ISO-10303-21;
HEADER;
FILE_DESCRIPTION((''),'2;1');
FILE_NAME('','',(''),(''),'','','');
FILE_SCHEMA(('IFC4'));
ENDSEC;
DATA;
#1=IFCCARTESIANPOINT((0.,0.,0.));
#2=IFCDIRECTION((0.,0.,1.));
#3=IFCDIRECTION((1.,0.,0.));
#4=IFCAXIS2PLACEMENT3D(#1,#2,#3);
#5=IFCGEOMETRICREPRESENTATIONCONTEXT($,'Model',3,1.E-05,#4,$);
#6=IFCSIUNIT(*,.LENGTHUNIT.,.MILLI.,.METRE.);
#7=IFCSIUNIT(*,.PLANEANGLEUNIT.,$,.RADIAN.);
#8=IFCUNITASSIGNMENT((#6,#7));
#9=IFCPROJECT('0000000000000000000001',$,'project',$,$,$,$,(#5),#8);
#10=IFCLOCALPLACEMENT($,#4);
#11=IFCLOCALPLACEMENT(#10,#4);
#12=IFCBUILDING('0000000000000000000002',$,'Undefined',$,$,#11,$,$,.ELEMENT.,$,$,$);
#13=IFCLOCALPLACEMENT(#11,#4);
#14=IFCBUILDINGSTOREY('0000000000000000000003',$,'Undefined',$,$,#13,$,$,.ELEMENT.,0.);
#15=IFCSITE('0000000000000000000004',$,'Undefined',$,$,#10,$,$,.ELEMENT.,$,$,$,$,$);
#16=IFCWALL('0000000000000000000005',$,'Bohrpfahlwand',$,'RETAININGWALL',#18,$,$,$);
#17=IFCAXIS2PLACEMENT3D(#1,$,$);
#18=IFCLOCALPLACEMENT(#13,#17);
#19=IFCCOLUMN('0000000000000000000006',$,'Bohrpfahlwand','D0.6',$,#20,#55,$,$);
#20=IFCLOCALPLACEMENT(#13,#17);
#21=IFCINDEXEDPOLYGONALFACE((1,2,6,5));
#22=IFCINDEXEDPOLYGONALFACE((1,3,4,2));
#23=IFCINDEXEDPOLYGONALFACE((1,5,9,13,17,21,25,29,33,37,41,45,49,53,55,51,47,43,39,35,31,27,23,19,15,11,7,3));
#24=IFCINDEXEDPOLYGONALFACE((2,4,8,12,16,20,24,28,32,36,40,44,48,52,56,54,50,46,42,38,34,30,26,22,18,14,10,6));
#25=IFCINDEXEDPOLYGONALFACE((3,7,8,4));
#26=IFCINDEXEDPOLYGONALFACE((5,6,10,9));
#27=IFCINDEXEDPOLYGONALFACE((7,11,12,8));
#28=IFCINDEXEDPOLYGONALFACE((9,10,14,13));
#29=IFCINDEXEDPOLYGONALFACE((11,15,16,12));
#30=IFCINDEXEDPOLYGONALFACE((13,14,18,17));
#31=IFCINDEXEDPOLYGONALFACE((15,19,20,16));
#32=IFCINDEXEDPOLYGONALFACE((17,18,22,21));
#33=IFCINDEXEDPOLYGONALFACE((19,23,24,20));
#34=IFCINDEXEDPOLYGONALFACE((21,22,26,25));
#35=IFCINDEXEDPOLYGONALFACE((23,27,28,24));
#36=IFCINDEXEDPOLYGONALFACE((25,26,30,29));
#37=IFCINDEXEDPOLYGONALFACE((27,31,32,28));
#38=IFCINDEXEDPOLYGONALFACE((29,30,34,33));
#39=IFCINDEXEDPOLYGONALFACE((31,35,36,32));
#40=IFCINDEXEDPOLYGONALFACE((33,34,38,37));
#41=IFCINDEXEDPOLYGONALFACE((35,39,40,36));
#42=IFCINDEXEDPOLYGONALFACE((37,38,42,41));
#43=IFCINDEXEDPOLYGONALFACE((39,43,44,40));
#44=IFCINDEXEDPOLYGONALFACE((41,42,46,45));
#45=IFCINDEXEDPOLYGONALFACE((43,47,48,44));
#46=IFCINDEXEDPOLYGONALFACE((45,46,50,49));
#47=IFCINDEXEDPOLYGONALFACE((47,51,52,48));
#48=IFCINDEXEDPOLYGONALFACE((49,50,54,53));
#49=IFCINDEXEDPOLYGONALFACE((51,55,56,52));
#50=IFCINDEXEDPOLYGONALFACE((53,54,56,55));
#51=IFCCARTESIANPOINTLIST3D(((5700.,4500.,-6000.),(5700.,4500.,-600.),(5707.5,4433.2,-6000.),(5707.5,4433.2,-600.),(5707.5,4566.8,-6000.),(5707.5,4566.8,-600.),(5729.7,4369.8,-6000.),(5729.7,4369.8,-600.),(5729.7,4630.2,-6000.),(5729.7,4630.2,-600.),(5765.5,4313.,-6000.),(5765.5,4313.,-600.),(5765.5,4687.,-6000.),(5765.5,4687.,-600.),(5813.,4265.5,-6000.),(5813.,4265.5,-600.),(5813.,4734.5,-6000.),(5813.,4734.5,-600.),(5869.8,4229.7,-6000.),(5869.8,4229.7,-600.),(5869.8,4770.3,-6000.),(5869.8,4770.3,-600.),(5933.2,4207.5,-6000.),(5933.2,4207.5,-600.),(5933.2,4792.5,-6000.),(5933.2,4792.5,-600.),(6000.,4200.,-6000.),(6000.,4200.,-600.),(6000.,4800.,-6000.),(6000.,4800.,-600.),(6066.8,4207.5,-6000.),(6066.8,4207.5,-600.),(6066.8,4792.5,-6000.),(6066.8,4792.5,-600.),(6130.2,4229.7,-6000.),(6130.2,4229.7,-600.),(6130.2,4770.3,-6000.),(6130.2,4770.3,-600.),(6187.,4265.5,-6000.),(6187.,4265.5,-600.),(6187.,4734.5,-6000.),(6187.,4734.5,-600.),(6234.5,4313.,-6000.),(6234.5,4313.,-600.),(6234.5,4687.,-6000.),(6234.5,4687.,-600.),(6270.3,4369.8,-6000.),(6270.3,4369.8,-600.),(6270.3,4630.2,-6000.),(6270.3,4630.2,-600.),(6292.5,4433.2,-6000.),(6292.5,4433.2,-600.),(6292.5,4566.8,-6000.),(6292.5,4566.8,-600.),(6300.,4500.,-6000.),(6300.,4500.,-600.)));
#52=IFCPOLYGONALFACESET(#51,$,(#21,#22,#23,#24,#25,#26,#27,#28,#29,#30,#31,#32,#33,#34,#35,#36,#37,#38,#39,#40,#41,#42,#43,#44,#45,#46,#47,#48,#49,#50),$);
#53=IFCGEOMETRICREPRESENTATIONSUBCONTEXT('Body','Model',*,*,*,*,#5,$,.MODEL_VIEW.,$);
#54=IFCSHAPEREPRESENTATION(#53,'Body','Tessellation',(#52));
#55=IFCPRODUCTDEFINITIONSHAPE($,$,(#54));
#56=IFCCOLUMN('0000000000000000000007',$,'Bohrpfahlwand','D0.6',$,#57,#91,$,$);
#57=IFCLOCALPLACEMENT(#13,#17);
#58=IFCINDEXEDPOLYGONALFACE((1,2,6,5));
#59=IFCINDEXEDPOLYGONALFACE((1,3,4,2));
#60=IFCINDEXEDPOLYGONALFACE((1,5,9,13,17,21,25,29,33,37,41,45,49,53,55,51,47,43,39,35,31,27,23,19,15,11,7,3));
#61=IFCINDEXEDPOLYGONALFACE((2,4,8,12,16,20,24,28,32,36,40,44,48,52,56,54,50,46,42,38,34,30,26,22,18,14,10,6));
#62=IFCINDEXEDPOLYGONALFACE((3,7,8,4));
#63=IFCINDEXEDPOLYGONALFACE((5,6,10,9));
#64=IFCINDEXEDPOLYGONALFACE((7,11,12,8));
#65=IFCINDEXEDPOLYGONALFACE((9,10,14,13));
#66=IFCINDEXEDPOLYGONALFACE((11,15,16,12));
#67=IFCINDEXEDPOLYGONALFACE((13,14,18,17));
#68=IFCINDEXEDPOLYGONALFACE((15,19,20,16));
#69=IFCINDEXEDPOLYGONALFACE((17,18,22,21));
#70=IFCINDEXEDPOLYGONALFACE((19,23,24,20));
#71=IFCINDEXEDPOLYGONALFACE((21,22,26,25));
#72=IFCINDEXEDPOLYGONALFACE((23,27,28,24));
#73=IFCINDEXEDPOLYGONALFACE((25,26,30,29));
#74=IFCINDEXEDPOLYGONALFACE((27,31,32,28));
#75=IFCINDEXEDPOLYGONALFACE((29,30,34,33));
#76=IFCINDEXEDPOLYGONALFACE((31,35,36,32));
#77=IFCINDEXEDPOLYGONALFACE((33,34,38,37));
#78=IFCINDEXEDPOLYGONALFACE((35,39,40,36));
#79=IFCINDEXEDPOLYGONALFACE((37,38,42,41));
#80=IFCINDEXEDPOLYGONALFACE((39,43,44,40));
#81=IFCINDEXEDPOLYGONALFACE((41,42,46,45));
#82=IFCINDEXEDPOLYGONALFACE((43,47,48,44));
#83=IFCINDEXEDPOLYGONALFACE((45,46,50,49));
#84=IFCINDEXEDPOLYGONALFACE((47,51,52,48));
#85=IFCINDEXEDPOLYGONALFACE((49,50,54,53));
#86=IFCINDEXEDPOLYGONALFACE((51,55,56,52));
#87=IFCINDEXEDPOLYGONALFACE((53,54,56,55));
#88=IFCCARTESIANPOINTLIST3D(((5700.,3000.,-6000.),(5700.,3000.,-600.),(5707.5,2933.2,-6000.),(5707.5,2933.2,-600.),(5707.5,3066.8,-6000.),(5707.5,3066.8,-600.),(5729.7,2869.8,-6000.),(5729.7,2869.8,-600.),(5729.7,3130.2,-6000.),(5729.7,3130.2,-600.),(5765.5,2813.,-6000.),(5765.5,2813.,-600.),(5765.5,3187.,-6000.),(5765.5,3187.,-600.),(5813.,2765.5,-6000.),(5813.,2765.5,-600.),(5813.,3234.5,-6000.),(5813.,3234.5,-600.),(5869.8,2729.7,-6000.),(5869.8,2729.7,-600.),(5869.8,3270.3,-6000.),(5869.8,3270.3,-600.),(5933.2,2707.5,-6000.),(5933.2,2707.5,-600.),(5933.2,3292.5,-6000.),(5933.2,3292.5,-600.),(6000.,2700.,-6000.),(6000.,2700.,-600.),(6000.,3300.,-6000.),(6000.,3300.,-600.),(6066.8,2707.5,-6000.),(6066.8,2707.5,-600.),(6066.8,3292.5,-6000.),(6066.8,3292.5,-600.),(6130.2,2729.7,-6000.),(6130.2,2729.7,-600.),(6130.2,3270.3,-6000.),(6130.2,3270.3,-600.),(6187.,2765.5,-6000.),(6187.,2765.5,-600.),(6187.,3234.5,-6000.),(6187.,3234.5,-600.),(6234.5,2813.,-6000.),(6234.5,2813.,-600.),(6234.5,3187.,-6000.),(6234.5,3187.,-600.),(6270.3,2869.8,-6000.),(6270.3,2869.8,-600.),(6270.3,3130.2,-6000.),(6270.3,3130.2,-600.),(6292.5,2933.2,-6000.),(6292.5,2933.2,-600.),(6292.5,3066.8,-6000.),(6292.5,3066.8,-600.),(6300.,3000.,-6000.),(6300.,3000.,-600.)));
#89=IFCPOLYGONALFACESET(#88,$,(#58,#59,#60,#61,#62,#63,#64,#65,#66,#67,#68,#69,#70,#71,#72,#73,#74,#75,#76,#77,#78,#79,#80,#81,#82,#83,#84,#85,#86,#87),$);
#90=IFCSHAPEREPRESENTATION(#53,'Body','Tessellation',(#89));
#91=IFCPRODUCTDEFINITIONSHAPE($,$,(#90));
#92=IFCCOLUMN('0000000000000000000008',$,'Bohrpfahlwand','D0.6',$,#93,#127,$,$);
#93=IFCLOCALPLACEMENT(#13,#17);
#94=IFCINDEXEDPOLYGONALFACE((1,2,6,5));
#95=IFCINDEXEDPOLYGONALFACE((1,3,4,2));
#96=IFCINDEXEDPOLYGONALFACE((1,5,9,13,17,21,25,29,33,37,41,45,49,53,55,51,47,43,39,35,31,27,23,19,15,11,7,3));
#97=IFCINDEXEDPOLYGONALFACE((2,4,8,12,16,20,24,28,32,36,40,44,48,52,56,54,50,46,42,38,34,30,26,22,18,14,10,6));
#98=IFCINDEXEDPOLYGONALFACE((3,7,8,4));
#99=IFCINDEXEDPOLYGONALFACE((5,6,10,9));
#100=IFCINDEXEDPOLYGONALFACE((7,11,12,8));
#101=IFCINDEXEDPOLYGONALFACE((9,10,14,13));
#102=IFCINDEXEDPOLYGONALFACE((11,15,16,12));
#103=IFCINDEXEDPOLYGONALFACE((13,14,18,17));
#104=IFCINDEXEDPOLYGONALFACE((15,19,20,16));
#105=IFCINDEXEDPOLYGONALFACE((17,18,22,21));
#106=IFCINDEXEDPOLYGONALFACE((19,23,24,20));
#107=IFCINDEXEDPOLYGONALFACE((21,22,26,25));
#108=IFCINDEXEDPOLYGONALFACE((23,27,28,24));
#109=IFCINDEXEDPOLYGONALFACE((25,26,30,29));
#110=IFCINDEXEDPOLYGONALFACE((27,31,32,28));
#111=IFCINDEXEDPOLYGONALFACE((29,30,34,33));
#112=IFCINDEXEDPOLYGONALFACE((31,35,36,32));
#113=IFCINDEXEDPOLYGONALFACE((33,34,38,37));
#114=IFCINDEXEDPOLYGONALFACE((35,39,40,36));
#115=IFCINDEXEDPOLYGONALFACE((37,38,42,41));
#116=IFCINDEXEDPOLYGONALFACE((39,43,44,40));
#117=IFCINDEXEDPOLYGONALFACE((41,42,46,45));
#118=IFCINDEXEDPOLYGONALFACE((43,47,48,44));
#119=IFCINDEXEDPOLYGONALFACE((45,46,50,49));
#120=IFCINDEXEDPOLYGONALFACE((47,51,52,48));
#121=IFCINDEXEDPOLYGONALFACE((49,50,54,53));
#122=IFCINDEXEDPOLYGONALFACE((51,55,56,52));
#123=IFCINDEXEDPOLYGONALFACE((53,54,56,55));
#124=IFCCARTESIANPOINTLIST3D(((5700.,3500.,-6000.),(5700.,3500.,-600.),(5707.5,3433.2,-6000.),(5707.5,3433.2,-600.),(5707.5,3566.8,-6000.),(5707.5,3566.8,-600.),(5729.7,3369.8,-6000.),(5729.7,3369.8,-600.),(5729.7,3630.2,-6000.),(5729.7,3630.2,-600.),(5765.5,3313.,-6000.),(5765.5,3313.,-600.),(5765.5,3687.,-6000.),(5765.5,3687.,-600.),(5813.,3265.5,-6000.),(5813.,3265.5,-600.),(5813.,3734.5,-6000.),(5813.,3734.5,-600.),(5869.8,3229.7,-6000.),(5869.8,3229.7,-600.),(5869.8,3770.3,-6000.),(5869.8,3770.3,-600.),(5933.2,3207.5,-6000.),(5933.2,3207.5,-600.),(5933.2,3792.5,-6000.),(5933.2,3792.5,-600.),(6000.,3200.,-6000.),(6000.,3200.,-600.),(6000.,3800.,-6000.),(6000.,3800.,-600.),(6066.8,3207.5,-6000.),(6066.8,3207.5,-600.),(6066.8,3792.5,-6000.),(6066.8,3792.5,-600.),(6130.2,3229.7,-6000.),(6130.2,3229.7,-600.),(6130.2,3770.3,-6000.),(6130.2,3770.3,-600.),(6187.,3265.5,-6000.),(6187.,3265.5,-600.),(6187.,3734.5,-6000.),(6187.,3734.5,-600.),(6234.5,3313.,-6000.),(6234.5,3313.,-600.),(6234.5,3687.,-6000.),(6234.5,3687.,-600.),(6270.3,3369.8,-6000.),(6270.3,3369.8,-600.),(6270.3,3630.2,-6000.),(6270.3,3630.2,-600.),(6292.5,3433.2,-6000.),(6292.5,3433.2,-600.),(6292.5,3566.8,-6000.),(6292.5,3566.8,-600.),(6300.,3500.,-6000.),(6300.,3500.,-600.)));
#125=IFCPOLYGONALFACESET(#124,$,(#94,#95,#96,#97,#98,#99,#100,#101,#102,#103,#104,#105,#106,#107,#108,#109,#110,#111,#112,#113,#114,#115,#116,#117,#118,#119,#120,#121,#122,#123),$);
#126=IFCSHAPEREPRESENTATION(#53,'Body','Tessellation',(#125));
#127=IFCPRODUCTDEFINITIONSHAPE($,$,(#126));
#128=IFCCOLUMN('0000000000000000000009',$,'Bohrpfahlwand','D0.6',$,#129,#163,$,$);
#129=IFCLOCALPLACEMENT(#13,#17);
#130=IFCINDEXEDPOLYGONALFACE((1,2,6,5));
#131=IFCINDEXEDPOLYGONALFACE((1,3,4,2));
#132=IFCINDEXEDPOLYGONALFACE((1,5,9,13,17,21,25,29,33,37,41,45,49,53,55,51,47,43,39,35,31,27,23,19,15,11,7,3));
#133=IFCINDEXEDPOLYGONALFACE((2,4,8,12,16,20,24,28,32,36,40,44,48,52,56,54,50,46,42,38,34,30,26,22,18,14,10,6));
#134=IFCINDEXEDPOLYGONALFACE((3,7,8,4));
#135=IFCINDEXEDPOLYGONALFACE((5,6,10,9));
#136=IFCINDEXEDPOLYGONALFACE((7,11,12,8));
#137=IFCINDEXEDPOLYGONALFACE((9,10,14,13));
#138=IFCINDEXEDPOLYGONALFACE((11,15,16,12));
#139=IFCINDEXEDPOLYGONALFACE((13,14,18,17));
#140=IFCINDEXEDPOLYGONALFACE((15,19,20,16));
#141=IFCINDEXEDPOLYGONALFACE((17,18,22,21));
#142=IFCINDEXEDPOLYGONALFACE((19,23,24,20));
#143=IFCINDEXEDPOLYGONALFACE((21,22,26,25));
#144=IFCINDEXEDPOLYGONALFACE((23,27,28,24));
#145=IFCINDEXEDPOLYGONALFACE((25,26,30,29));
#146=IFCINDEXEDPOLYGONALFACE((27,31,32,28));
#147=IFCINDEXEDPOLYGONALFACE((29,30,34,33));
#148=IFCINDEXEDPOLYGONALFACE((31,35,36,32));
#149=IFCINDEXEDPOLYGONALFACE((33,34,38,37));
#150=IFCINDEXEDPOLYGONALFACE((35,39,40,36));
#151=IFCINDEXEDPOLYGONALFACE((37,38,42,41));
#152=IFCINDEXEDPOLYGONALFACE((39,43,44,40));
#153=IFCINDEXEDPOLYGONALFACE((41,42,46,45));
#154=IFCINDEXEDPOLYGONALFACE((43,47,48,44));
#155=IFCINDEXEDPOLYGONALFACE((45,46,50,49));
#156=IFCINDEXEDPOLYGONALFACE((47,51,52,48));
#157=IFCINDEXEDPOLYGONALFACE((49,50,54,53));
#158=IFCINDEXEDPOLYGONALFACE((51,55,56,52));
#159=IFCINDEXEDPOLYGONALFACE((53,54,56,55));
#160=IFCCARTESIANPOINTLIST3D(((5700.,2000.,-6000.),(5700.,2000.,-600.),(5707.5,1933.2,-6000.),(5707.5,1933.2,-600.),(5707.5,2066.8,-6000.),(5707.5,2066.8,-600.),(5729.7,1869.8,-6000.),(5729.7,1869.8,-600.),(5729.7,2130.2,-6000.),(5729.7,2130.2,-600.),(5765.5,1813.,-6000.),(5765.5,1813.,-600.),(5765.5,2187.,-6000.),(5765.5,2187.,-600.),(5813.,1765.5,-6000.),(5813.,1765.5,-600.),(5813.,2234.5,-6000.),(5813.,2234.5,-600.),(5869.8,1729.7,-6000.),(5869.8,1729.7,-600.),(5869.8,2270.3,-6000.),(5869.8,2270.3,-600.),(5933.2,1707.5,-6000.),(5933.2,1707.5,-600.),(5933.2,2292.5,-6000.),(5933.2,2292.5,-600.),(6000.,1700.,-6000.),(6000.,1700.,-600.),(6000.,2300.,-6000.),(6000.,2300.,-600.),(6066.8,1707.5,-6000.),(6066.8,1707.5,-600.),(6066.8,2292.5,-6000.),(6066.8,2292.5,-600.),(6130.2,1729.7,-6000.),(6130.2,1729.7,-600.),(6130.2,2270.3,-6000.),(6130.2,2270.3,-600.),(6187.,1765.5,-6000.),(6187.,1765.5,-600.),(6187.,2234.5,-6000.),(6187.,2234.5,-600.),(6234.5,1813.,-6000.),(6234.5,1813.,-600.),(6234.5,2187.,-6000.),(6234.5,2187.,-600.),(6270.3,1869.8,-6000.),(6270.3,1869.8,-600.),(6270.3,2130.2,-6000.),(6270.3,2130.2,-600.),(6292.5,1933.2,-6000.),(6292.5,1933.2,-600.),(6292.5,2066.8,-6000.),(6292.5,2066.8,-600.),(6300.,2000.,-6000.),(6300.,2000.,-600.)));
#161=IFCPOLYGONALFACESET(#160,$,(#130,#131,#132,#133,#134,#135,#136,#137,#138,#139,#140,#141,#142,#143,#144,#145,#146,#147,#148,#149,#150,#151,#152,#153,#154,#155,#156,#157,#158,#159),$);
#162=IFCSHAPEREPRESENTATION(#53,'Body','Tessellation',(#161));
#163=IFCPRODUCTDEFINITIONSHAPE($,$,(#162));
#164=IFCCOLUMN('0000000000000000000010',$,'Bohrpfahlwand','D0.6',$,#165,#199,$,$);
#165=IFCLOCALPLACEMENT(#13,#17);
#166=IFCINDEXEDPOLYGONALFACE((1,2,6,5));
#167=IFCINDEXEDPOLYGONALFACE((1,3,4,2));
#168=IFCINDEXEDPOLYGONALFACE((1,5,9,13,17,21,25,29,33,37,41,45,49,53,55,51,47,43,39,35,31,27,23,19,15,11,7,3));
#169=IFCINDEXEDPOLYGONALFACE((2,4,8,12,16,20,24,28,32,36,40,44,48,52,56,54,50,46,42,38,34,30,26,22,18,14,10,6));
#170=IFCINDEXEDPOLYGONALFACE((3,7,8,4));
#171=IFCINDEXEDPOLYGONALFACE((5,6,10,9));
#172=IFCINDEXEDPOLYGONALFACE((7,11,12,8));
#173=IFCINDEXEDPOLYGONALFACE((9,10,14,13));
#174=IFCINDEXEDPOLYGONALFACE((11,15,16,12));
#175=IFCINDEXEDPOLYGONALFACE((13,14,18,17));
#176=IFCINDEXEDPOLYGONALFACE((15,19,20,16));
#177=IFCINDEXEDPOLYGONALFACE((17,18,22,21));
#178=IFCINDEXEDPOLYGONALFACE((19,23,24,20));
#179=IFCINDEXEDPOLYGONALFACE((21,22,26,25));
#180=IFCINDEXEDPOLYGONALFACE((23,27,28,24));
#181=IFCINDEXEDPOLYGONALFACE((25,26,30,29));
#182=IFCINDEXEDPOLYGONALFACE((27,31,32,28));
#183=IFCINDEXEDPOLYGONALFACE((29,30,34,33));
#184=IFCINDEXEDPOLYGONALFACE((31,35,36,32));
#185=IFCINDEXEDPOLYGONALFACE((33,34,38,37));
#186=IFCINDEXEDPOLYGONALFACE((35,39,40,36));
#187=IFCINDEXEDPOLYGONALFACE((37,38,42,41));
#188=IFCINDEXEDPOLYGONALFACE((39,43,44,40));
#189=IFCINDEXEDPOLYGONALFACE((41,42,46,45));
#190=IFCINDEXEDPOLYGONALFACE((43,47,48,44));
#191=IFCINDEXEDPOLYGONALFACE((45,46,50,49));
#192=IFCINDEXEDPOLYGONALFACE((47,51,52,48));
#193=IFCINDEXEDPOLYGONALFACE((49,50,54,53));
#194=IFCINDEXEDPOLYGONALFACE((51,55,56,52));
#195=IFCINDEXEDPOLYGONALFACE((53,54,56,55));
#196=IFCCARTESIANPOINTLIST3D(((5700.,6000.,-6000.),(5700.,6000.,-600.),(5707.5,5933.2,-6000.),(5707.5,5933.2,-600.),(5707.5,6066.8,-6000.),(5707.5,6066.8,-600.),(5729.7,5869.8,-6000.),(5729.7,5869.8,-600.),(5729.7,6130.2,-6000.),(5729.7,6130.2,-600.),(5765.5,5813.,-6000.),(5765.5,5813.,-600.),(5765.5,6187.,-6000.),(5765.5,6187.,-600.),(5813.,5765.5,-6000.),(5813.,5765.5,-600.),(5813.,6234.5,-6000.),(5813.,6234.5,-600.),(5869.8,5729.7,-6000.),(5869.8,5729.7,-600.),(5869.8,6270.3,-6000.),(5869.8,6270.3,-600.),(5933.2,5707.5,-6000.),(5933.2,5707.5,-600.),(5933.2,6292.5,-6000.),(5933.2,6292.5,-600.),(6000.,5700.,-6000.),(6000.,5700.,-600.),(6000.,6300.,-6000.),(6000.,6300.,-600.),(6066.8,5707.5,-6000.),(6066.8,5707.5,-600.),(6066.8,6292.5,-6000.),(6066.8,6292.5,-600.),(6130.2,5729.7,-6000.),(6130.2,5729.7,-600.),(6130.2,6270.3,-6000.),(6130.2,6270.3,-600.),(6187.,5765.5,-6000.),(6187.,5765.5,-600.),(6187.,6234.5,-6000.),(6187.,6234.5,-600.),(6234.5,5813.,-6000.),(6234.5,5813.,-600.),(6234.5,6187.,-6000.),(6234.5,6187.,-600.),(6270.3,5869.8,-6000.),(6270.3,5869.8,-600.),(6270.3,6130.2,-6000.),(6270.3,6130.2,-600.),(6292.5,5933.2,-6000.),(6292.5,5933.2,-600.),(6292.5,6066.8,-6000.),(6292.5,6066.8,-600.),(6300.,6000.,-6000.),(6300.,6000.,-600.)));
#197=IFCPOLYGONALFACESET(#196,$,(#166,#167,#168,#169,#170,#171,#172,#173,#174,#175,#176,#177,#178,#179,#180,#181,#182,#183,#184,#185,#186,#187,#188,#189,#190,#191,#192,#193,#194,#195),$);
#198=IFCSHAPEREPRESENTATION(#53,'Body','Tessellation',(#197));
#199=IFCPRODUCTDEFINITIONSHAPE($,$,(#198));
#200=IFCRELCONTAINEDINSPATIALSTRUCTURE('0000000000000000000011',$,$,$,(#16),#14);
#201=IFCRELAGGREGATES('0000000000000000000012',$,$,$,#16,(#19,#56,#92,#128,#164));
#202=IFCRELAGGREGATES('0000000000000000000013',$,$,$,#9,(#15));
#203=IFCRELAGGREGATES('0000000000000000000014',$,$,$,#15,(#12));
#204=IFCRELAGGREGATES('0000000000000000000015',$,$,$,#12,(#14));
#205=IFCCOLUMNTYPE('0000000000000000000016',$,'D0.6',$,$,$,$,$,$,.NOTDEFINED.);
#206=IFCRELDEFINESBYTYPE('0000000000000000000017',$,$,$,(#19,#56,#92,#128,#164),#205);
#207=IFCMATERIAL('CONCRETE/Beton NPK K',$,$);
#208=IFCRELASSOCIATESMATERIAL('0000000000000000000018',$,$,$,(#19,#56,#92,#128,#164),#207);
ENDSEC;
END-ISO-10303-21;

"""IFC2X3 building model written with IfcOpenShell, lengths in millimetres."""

from ifc_helpers import new_model, si_unit, frame, origin_with_axes, origin_2d_with_axis, place, context, subcontext, project, spatial, circle, extrude, material, type_object, element, aggregate, save


model = new_model("IFC2X3")

# Units and contexts
model_context = context("Model", 3, precision=1e-05, world=origin_with_axes())
body_context = subcontext(model_context, "Body", "Model", "MODEL_VIEW")
ifc_project = project(units=[si_unit("LENGTHUNIT", "METRE", prefix="MILLI"), si_unit("PLANEANGLEUNIT", "RADIAN")], contexts=[model_context])

# Site, building, storey
site_placement = place(None, origin_with_axes())
site = spatial("IfcSite", under=ifc_project, at=site_placement, Name="Undefined", CompositionType="ELEMENT")
building_placement = place(site_placement, origin_with_axes())
building = spatial("IfcBuilding", under=site, at=building_placement, Name="Undefined", CompositionType="ELEMENT")
storey_placement = place(building_placement, origin_with_axes())
storey = spatial("IfcBuildingStorey", under=building, at=storey_placement, Name="Undefined", CompositionType="ELEMENT", Elevation=0.0)

# Shared definitions
ifc_material_1 = material(Name="CONCRETE/Beton NPK K")

# Wall, columns
wall_1_placement = place(storey_placement, origin_with_axes())
wall_1 = element("IfcWall", 1, at=wall_1_placement, inside=storey, Name="Bohrpfahlwand", ObjectType="RETAININGWALL")
column_type = type_object("IfcColumnType", Name="D0.6", PredefinedType="NOTDEFINED")
column_1_placement = place(wall_1_placement, frame((6000.0, 4500.0, -6000.0), z_axis=(0.0, 0.0, 1.0), x_axis=(0.0, 1.0, 0.0)))
column_1 = element("IfcColumn", 2, at=column_1_placement, type_object=column_type, material=ifc_material_1, Name="Bohrpfahlwand", Description="D0.6", context=body_context, shape_type="SweptSolid", body=[
    extrude(circle(Radius=300.0, at=origin_2d_with_axis()), frame((0.0, 0.0, 5400.0), z_axis=(0.0, 0.0, -1.0), x_axis=(0.0, 1.0, 0.0)), (0.0, 0.0, 1.0), 5400.0),
])
column_2_placement = place(wall_1_placement, frame((6000.0, 3000.0, -6000.0), z_axis=(0.0, 0.0, 1.0), x_axis=(0.0, 1.0, 0.0)))
column_2 = element("IfcColumn", 3, at=column_2_placement, type_object=column_type, material=ifc_material_1, Name="Bohrpfahlwand", Description="D0.6", context=body_context, shape_type="SweptSolid", body=[
    extrude(circle(Radius=300.0, at=origin_2d_with_axis()), frame((0.0, 0.0, 5400.0), z_axis=(0.0, 0.0, -1.0), x_axis=(0.0, 1.0, 0.0)), (0.0, 0.0, 1.0), 5400.0),
])
column_3_placement = place(wall_1_placement, frame((6000.0, 3500.0, -6000.0), z_axis=(0.0, 0.0, 1.0), x_axis=(0.0, 1.0, 0.0)))
column_3 = element("IfcColumn", 4, at=column_3_placement, type_object=column_type, material=ifc_material_1, Name="Bohrpfahlwand", Description="D0.6", context=body_context, shape_type="SweptSolid", body=[
    extrude(circle(Radius=300.0, at=origin_2d_with_axis()), frame((0.0, 0.0, 5400.0), z_axis=(0.0, 0.0, -1.0), x_axis=(0.0, 1.0, 0.0)), (0.0, 0.0, 1.0), 5400.0),
])
column_4_placement = place(wall_1_placement, frame((6000.0, 2000.0, -6000.0), z_axis=(0.0, 0.0, 1.0), x_axis=(0.0, 1.0, 0.0)))
column_4 = element("IfcColumn", 5, at=column_4_placement, type_object=column_type, material=ifc_material_1, Name="Bohrpfahlwand", Description="D0.6", context=body_context, shape_type="SweptSolid", body=[
    extrude(circle(Radius=300.0, at=origin_2d_with_axis()), frame((0.0, 0.0, 5400.0), z_axis=(0.0, 0.0, -1.0), x_axis=(0.0, 1.0, 0.0)), (0.0, 0.0, 1.0), 5400.0),
])
column_5_placement = place(wall_1_placement, frame((6000.0, 6000.0, -6000.0), z_axis=(0.0, 0.0, 1.0), x_axis=(0.0, 1.0, 0.0)))
column_5 = element("IfcColumn", 6, at=column_5_placement, type_object=column_type, material=ifc_material_1, Name="Bohrpfahlwand", Description="D0.6", context=body_context, shape_type="SweptSolid", body=[
    extrude(circle(Radius=300.0, at=origin_2d_with_axis()), frame((0.0, 0.0, 5400.0), z_axis=(0.0, 0.0, -1.0), x_axis=(0.0, 1.0, 0.0)), (0.0, 0.0, 1.0), 5400.0),
])
aggregate(wall_1, [column_1, column_2, column_3, column_4, column_5])

save(model, "model.ifc")
